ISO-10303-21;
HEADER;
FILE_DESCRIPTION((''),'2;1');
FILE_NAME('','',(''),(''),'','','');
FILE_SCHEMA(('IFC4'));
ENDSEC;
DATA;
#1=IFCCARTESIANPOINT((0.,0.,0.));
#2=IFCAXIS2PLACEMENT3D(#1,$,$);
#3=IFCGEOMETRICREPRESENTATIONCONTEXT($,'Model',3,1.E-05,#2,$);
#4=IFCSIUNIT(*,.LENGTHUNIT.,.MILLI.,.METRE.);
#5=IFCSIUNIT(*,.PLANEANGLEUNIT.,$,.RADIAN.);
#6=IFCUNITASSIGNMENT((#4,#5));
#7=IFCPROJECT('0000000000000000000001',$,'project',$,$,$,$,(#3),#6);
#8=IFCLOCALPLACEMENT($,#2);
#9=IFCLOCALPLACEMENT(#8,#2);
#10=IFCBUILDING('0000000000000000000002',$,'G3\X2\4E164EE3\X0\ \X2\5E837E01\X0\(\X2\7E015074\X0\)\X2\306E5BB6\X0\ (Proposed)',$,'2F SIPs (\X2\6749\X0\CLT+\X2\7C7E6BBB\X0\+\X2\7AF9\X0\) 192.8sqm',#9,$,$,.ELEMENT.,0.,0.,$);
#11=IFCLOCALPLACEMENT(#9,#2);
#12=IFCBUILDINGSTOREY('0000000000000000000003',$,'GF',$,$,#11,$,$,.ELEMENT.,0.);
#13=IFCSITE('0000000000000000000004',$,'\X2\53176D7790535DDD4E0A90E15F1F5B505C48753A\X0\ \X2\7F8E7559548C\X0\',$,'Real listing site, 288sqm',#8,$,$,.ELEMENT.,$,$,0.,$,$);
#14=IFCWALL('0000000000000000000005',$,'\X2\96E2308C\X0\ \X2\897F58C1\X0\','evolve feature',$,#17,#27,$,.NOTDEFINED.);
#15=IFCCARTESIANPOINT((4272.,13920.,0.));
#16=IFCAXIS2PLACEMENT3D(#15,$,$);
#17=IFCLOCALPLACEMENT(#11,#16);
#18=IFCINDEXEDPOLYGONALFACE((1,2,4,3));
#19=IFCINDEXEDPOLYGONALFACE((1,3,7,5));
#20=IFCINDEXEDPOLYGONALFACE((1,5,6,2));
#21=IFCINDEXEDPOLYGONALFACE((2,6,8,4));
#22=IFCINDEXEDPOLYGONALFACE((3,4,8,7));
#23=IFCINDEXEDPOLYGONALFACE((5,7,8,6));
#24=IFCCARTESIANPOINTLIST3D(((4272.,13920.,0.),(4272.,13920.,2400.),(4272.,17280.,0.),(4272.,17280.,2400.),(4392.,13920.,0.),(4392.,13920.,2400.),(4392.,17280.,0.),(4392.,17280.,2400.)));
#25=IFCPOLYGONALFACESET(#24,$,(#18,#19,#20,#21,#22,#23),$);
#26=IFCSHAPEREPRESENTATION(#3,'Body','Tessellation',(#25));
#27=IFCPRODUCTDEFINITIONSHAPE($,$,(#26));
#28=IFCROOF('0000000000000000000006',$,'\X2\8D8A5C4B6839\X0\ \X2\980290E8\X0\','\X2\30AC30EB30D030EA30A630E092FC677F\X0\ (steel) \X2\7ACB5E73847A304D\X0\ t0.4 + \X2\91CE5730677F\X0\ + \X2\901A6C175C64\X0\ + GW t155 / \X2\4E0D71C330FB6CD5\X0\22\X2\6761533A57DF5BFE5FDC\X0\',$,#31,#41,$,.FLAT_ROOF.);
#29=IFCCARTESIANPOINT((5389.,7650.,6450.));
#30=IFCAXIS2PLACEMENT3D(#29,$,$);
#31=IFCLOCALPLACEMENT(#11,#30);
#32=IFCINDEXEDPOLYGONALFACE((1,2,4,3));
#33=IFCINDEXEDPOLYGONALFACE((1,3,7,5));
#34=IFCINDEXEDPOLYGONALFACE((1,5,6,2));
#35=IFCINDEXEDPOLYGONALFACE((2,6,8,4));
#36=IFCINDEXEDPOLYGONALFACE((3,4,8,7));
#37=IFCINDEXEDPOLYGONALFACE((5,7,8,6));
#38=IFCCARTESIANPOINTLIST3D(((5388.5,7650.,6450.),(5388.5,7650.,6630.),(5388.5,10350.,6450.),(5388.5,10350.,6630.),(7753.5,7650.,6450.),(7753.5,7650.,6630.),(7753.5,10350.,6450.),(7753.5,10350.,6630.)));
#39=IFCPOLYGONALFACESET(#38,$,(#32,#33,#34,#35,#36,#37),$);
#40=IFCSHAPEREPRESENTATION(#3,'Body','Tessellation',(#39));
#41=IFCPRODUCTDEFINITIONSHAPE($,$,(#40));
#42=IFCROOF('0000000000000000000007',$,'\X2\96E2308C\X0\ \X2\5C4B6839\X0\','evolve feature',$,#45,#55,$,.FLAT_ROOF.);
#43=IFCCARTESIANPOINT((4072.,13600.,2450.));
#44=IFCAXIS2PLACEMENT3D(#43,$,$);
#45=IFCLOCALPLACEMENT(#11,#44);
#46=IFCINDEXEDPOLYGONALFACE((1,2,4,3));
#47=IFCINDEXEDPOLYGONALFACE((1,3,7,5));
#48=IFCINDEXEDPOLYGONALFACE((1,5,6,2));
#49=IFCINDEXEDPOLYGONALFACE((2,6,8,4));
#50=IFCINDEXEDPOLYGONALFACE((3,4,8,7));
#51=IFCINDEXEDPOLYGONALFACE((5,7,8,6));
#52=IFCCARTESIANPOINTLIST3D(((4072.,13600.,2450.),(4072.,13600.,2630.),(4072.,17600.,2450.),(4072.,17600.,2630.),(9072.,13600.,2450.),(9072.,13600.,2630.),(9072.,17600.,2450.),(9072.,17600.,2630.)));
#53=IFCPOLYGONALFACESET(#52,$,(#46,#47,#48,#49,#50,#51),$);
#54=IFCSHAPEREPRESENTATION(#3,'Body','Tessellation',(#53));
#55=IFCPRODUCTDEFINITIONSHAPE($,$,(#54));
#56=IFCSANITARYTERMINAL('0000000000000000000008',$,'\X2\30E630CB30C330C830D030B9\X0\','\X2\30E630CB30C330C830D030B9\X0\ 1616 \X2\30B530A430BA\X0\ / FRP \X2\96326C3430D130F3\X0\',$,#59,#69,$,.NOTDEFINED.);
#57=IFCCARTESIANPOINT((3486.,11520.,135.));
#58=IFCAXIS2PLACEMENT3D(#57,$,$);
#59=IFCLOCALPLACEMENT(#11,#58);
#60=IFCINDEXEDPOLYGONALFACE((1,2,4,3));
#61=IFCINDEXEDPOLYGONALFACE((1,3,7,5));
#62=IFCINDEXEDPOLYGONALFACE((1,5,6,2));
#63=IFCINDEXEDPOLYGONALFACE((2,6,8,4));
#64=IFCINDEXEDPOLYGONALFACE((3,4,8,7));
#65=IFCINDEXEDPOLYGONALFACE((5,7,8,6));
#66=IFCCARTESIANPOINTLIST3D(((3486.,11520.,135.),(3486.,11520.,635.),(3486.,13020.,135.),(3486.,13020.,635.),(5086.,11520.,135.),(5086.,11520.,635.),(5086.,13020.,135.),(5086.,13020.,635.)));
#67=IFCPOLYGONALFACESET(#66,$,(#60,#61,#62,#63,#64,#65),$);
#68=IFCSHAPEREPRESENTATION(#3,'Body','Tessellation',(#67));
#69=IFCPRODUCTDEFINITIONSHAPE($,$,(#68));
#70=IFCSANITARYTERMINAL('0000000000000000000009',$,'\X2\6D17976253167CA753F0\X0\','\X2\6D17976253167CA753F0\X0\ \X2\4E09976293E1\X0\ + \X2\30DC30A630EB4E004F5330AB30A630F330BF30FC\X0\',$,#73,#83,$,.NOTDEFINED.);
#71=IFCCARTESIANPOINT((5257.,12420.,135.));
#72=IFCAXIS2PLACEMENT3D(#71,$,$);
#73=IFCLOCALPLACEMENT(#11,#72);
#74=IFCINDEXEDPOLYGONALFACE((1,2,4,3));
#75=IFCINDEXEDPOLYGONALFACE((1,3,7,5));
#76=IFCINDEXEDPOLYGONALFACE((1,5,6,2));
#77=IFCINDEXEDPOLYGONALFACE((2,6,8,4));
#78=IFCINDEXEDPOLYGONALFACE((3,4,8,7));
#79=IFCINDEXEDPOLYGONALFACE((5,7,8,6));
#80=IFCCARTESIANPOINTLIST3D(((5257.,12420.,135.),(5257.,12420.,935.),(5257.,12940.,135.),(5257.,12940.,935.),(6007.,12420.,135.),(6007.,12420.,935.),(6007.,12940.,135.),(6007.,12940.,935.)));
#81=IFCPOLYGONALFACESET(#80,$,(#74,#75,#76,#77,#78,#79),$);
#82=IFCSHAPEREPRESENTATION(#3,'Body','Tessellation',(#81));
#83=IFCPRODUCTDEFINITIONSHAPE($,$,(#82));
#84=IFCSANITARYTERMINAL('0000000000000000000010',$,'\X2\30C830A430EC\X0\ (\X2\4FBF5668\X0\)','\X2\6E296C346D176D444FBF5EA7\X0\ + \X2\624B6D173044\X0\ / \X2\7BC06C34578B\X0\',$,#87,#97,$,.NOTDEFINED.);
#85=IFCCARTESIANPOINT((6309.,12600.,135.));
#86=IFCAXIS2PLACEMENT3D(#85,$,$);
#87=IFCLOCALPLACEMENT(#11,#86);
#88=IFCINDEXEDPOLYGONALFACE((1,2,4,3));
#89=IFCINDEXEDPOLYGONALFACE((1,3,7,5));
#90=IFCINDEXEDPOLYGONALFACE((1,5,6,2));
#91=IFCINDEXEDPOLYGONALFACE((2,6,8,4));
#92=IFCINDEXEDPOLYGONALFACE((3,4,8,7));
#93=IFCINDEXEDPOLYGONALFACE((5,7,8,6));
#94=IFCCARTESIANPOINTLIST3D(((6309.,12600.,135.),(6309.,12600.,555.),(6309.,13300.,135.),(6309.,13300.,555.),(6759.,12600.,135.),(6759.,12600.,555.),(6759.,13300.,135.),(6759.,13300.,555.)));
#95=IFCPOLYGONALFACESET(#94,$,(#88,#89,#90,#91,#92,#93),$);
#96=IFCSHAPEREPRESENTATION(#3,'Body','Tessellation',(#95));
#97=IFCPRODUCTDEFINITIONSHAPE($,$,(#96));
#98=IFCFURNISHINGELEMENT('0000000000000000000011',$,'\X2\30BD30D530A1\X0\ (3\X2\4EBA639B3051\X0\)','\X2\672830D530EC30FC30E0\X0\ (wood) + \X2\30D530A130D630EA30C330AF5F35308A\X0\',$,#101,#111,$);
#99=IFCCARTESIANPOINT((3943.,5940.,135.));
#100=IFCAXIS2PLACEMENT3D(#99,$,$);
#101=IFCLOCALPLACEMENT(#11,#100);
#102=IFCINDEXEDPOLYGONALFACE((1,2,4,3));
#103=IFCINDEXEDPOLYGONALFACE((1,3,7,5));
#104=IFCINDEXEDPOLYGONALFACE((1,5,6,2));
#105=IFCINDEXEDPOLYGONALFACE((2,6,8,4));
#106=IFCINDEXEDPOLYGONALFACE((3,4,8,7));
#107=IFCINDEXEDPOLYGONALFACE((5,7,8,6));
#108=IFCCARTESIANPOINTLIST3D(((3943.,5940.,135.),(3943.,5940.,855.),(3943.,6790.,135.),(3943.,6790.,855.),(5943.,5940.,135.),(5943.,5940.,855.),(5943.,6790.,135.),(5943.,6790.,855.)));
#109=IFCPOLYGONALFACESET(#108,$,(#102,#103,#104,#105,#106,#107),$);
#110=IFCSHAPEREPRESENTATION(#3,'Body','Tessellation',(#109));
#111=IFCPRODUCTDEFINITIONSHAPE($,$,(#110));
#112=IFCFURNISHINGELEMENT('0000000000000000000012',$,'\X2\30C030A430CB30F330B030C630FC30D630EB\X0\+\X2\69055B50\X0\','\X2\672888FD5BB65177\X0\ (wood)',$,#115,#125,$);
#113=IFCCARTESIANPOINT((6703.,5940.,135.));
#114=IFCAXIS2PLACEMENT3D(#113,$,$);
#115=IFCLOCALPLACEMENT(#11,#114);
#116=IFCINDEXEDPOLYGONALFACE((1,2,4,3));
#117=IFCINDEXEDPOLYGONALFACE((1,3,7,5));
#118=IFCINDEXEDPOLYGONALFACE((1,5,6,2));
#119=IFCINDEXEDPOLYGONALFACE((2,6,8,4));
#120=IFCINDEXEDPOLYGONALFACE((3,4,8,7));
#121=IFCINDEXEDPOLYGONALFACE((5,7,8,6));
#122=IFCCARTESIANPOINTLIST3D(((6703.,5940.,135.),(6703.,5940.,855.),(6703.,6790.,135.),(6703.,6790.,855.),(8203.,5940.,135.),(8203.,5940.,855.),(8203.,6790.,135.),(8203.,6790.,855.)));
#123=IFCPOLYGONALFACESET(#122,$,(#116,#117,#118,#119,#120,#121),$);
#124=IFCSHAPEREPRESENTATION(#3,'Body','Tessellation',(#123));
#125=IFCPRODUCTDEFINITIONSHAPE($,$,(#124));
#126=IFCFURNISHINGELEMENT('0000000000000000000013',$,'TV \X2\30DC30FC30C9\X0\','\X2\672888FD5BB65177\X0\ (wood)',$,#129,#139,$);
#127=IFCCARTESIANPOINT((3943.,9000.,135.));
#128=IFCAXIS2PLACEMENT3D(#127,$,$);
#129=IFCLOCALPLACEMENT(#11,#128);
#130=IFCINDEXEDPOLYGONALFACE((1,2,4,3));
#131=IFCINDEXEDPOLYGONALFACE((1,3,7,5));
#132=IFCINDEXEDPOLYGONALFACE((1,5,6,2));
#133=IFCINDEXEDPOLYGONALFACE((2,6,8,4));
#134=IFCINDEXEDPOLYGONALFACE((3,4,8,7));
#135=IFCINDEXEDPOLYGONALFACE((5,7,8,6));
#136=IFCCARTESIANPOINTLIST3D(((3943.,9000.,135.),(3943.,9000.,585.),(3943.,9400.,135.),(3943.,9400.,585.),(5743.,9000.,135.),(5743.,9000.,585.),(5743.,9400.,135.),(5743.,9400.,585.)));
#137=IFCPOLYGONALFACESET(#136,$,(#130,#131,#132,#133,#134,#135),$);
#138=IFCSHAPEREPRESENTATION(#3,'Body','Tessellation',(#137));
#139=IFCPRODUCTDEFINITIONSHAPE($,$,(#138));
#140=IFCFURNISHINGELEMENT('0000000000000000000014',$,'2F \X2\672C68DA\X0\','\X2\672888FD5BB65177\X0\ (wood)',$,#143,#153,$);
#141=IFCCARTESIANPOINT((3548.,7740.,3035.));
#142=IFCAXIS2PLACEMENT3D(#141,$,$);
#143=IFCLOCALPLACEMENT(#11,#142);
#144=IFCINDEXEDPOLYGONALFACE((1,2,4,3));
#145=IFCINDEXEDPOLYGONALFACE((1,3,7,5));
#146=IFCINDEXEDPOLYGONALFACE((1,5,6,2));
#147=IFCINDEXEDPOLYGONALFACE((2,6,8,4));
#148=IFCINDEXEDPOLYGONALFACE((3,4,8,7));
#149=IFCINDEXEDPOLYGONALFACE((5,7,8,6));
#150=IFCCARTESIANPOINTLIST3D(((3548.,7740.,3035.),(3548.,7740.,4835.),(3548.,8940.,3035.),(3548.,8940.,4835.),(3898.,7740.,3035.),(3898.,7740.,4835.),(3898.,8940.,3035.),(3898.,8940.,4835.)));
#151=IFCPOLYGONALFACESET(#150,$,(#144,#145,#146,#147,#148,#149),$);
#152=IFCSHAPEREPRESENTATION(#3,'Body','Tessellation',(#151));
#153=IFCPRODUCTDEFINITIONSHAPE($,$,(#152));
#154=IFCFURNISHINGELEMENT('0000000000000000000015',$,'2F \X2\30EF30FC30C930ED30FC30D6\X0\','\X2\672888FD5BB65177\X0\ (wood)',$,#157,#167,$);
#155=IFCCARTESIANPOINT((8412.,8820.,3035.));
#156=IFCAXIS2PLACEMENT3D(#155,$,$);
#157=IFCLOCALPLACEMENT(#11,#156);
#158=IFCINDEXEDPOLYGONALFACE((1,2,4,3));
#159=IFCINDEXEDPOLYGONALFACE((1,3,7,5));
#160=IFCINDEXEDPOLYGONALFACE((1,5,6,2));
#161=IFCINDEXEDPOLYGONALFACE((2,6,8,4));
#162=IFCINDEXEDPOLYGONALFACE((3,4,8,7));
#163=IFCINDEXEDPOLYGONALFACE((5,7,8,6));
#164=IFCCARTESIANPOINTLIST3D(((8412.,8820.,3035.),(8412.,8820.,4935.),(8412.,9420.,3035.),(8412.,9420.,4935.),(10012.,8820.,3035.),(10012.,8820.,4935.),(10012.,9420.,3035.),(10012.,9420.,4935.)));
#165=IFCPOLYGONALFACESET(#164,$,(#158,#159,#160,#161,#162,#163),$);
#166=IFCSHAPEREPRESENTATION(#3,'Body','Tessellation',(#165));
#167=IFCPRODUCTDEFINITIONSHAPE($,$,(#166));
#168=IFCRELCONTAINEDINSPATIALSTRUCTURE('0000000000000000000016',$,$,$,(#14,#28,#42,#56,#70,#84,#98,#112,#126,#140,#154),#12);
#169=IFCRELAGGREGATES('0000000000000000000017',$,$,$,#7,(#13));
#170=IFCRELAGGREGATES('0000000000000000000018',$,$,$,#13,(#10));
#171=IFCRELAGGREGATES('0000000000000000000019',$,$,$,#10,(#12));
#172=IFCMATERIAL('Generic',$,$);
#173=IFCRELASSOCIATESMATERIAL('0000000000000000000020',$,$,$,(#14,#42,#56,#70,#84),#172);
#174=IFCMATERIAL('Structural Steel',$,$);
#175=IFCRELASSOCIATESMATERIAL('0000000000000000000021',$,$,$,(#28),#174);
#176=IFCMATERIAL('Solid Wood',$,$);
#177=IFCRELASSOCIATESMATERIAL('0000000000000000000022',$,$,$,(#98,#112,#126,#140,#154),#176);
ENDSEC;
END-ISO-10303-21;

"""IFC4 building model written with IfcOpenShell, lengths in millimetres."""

from ifc_helpers import new_model, si_unit, frame, frame_2d, origin, place, context, project, spatial, rectangle, extrude, material, element, save


model = new_model("IFC4")

# Units and contexts
model_context = context("Model", 3, precision=1e-05, world=origin())
ifc_project = project(units=[si_unit("LENGTHUNIT", "METRE", prefix="MILLI"), si_unit("PLANEANGLEUNIT", "RADIAN")], contexts=[model_context])

# Site, building, storey
site_placement = place(None, origin())
site = spatial("IfcSite", under=ifc_project, at=site_placement, Name="北海道川上郡弟子屈町 美留和", ObjectType="Real listing site, 288sqm", CompositionType="ELEMENT", RefElevation=0.0)
building_placement = place(site_placement, origin())
building = spatial("IfcBuilding", under=site, at=building_placement, Name="G3世代 広縁(縁側)の家 (Proposed)", ObjectType="2F SIPs (杉CLT+籾殻+竹) 192.8sqm", CompositionType="ELEMENT", ElevationOfRefHeight=0.0, ElevationOfTerrain=0.0)
storey_placement = place(building_placement, origin())
storey = spatial("IfcBuildingStorey", under=building, at=storey_placement, Name="GF", CompositionType="ELEMENT", Elevation=0.0)

# Shared definitions
ifc_material_1 = material(Name="Generic")

# Shared definitions
ifc_material_2 = material(Name="Solid Wood")

# Wall
wall_1_placement = place(storey_placement, frame((4272.0, 13920.0, 0.0)))
element("IfcWall", 1, at=wall_1_placement, inside=storey, material=ifc_material_1, Name="離れ 西壁", Description="evolve feature", PredefinedType="NOTDEFINED", context=model_context, shape_type="SweptSolid", body=[
    extrude(rectangle(XDim=120.0, YDim=3360.0, at=frame_2d((60.0, 1680.0))), frame((4272.0, 13920.0, 0.0)), (0.0, 0.0, 1.0), 2400.0),
])

# Roofs
ifc_material_3 = material(Name="Structural Steel")
roof_1_placement = place(storey_placement, frame((5389.0, 7650.0, 6450.0)))
element("IfcRoof", 2, at=roof_1_placement, inside=storey, material=ifc_material_3, Name="越屋根 頂部", Description="ガルバリウム鋼板 (steel) 立平葺き t0.4 + 野地板 + 通気層 + GW t155 / 不燃・法22条区域対応", PredefinedType="FLAT_ROOF", context=model_context, shape_type="SweptSolid", body=[
    extrude(rectangle(XDim=2365.0, YDim=2700.0, at=frame_2d((1182.0, 1350.0))), frame((5389.0, 7650.0, 6450.0)), (0.0, 0.0, 1.0), 180.0),
])
roof_2_placement = place(storey_placement, frame((4072.0, 13600.0, 2450.0)))
element("IfcRoof", 3, at=roof_2_placement, inside=storey, material=ifc_material_1, Name="離れ 屋根", Description="evolve feature", PredefinedType="FLAT_ROOF", context=model_context, shape_type="SweptSolid", body=[
    extrude(rectangle(XDim=5000.0, YDim=4000.0, at=frame_2d((2500.0, 2000.0))), frame((4072.0, 13600.0, 2450.0)), (0.0, 0.0, 1.0), 180.0),
])

# Sanitary terminals
sanitary_terminal_1_placement = place(storey_placement, frame((3486.0, 11520.0, 135.0)))
element("IfcSanitaryTerminal", 4, at=sanitary_terminal_1_placement, inside=storey, material=ifc_material_1, Name="ユニットバス", Description="ユニットバス 1616 サイズ / FRP 防水パン", PredefinedType="NOTDEFINED", context=model_context, shape_type="SweptSolid", body=[
    extrude(rectangle(XDim=1600.0, YDim=1500.0, at=frame_2d((800.0, 750.0))), frame((3486.0, 11520.0, 135.0)), (0.0, 0.0, 1.0), 500.0),
])
sanitary_terminal_2_placement = place(storey_placement, frame((5257.0, 12420.0, 135.0)))
element("IfcSanitaryTerminal", 5, at=sanitary_terminal_2_placement, inside=storey, material=ifc_material_1, Name="洗面化粧台", Description="洗面化粧台 三面鏡 + ボウル一体カウンター", PredefinedType="NOTDEFINED", context=model_context, shape_type="SweptSolid", body=[
    extrude(rectangle(XDim=750.0, YDim=520.0, at=frame_2d((375.0, 260.0))), frame((5257.0, 12420.0, 135.0)), (0.0, 0.0, 1.0), 800.0),
])
sanitary_terminal_3_placement = place(storey_placement, frame((6309.0, 12600.0, 135.0)))
element("IfcSanitaryTerminal", 6, at=sanitary_terminal_3_placement, inside=storey, material=ifc_material_1, Name="トイレ (便器)", Description="温水洗浄便座 + 手洗い / 節水型", PredefinedType="NOTDEFINED", context=model_context, shape_type="SweptSolid", body=[
    extrude(rectangle(XDim=450.0, YDim=700.0, at=frame_2d((225.0, 350.0))), frame((6309.0, 12600.0, 135.0)), (0.0, 0.0, 1.0), 420.0),
])

# Furnishing elements
furnishing_1_placement = place(storey_placement, frame((3943.0, 5940.0, 135.0)))
element("IfcFurnishingElement", 7, at=furnishing_1_placement, inside=storey, material=ifc_material_2, Name="ソファ (3人掛け)", Description="木フレーム (wood) + ファブリック張り", context=model_context, shape_type="SweptSolid", body=[
    extrude(rectangle(XDim=2000.0, YDim=850.0, at=frame_2d((1000.0, 425.0))), frame((3943.0, 5940.0, 135.0)), (0.0, 0.0, 1.0), 720.0),
])
furnishing_2_placement = place(storey_placement, frame((6703.0, 5940.0, 135.0)))
element("IfcFurnishingElement", 8, at=furnishing_2_placement, inside=storey, material=ifc_material_2, Name="ダイニングテーブル+椅子", Description="木製家具 (wood)", context=model_context, shape_type="SweptSolid", body=[
    extrude(rectangle(XDim=1500.0, YDim=850.0, at=frame_2d((750.0, 425.0))), frame((6703.0, 5940.0, 135.0)), (0.0, 0.0, 1.0), 720.0),
])
furnishing_3_placement = place(storey_placement, frame((3943.0, 9000.0, 135.0)))
element("IfcFurnishingElement", 9, at=furnishing_3_placement, inside=storey, material=ifc_material_2, Name="TV ボード", Description="木製家具 (wood)", context=model_context, shape_type="SweptSolid", body=[
    extrude(rectangle(XDim=1800.0, YDim=400.0, at=frame_2d((900.0, 200.0))), frame((3943.0, 9000.0, 135.0)), (0.0, 0.0, 1.0), 450.0),
])
furnishing_4_placement = place(storey_placement, frame((3548.0, 7740.0, 3035.0)))
element("IfcFurnishingElement", 10, at=furnishing_4_placement, inside=storey, material=ifc_material_2, Name="2F 本棚", Description="木製家具 (wood)", context=model_context, shape_type="SweptSolid", body=[
    extrude(rectangle(XDim=350.0, YDim=1200.0, at=frame_2d((175.0, 600.0))), frame((3548.0, 7740.0, 3035.0)), (0.0, 0.0, 1.0), 1800.0),
])
furnishing_5_placement = place(storey_placement, frame((8412.0, 8820.0, 3035.0)))
element("IfcFurnishingElement", 11, at=furnishing_5_placement, inside=storey, material=ifc_material_2, Name="2F ワードローブ", Description="木製家具 (wood)", context=model_context, shape_type="SweptSolid", body=[
    extrude(rectangle(XDim=1600.0, YDim=600.0, at=frame_2d((800.0, 300.0))), frame((8412.0, 8820.0, 3035.0)), (0.0, 0.0, 1.0), 1900.0),
])

save(model, "model.ifc")
